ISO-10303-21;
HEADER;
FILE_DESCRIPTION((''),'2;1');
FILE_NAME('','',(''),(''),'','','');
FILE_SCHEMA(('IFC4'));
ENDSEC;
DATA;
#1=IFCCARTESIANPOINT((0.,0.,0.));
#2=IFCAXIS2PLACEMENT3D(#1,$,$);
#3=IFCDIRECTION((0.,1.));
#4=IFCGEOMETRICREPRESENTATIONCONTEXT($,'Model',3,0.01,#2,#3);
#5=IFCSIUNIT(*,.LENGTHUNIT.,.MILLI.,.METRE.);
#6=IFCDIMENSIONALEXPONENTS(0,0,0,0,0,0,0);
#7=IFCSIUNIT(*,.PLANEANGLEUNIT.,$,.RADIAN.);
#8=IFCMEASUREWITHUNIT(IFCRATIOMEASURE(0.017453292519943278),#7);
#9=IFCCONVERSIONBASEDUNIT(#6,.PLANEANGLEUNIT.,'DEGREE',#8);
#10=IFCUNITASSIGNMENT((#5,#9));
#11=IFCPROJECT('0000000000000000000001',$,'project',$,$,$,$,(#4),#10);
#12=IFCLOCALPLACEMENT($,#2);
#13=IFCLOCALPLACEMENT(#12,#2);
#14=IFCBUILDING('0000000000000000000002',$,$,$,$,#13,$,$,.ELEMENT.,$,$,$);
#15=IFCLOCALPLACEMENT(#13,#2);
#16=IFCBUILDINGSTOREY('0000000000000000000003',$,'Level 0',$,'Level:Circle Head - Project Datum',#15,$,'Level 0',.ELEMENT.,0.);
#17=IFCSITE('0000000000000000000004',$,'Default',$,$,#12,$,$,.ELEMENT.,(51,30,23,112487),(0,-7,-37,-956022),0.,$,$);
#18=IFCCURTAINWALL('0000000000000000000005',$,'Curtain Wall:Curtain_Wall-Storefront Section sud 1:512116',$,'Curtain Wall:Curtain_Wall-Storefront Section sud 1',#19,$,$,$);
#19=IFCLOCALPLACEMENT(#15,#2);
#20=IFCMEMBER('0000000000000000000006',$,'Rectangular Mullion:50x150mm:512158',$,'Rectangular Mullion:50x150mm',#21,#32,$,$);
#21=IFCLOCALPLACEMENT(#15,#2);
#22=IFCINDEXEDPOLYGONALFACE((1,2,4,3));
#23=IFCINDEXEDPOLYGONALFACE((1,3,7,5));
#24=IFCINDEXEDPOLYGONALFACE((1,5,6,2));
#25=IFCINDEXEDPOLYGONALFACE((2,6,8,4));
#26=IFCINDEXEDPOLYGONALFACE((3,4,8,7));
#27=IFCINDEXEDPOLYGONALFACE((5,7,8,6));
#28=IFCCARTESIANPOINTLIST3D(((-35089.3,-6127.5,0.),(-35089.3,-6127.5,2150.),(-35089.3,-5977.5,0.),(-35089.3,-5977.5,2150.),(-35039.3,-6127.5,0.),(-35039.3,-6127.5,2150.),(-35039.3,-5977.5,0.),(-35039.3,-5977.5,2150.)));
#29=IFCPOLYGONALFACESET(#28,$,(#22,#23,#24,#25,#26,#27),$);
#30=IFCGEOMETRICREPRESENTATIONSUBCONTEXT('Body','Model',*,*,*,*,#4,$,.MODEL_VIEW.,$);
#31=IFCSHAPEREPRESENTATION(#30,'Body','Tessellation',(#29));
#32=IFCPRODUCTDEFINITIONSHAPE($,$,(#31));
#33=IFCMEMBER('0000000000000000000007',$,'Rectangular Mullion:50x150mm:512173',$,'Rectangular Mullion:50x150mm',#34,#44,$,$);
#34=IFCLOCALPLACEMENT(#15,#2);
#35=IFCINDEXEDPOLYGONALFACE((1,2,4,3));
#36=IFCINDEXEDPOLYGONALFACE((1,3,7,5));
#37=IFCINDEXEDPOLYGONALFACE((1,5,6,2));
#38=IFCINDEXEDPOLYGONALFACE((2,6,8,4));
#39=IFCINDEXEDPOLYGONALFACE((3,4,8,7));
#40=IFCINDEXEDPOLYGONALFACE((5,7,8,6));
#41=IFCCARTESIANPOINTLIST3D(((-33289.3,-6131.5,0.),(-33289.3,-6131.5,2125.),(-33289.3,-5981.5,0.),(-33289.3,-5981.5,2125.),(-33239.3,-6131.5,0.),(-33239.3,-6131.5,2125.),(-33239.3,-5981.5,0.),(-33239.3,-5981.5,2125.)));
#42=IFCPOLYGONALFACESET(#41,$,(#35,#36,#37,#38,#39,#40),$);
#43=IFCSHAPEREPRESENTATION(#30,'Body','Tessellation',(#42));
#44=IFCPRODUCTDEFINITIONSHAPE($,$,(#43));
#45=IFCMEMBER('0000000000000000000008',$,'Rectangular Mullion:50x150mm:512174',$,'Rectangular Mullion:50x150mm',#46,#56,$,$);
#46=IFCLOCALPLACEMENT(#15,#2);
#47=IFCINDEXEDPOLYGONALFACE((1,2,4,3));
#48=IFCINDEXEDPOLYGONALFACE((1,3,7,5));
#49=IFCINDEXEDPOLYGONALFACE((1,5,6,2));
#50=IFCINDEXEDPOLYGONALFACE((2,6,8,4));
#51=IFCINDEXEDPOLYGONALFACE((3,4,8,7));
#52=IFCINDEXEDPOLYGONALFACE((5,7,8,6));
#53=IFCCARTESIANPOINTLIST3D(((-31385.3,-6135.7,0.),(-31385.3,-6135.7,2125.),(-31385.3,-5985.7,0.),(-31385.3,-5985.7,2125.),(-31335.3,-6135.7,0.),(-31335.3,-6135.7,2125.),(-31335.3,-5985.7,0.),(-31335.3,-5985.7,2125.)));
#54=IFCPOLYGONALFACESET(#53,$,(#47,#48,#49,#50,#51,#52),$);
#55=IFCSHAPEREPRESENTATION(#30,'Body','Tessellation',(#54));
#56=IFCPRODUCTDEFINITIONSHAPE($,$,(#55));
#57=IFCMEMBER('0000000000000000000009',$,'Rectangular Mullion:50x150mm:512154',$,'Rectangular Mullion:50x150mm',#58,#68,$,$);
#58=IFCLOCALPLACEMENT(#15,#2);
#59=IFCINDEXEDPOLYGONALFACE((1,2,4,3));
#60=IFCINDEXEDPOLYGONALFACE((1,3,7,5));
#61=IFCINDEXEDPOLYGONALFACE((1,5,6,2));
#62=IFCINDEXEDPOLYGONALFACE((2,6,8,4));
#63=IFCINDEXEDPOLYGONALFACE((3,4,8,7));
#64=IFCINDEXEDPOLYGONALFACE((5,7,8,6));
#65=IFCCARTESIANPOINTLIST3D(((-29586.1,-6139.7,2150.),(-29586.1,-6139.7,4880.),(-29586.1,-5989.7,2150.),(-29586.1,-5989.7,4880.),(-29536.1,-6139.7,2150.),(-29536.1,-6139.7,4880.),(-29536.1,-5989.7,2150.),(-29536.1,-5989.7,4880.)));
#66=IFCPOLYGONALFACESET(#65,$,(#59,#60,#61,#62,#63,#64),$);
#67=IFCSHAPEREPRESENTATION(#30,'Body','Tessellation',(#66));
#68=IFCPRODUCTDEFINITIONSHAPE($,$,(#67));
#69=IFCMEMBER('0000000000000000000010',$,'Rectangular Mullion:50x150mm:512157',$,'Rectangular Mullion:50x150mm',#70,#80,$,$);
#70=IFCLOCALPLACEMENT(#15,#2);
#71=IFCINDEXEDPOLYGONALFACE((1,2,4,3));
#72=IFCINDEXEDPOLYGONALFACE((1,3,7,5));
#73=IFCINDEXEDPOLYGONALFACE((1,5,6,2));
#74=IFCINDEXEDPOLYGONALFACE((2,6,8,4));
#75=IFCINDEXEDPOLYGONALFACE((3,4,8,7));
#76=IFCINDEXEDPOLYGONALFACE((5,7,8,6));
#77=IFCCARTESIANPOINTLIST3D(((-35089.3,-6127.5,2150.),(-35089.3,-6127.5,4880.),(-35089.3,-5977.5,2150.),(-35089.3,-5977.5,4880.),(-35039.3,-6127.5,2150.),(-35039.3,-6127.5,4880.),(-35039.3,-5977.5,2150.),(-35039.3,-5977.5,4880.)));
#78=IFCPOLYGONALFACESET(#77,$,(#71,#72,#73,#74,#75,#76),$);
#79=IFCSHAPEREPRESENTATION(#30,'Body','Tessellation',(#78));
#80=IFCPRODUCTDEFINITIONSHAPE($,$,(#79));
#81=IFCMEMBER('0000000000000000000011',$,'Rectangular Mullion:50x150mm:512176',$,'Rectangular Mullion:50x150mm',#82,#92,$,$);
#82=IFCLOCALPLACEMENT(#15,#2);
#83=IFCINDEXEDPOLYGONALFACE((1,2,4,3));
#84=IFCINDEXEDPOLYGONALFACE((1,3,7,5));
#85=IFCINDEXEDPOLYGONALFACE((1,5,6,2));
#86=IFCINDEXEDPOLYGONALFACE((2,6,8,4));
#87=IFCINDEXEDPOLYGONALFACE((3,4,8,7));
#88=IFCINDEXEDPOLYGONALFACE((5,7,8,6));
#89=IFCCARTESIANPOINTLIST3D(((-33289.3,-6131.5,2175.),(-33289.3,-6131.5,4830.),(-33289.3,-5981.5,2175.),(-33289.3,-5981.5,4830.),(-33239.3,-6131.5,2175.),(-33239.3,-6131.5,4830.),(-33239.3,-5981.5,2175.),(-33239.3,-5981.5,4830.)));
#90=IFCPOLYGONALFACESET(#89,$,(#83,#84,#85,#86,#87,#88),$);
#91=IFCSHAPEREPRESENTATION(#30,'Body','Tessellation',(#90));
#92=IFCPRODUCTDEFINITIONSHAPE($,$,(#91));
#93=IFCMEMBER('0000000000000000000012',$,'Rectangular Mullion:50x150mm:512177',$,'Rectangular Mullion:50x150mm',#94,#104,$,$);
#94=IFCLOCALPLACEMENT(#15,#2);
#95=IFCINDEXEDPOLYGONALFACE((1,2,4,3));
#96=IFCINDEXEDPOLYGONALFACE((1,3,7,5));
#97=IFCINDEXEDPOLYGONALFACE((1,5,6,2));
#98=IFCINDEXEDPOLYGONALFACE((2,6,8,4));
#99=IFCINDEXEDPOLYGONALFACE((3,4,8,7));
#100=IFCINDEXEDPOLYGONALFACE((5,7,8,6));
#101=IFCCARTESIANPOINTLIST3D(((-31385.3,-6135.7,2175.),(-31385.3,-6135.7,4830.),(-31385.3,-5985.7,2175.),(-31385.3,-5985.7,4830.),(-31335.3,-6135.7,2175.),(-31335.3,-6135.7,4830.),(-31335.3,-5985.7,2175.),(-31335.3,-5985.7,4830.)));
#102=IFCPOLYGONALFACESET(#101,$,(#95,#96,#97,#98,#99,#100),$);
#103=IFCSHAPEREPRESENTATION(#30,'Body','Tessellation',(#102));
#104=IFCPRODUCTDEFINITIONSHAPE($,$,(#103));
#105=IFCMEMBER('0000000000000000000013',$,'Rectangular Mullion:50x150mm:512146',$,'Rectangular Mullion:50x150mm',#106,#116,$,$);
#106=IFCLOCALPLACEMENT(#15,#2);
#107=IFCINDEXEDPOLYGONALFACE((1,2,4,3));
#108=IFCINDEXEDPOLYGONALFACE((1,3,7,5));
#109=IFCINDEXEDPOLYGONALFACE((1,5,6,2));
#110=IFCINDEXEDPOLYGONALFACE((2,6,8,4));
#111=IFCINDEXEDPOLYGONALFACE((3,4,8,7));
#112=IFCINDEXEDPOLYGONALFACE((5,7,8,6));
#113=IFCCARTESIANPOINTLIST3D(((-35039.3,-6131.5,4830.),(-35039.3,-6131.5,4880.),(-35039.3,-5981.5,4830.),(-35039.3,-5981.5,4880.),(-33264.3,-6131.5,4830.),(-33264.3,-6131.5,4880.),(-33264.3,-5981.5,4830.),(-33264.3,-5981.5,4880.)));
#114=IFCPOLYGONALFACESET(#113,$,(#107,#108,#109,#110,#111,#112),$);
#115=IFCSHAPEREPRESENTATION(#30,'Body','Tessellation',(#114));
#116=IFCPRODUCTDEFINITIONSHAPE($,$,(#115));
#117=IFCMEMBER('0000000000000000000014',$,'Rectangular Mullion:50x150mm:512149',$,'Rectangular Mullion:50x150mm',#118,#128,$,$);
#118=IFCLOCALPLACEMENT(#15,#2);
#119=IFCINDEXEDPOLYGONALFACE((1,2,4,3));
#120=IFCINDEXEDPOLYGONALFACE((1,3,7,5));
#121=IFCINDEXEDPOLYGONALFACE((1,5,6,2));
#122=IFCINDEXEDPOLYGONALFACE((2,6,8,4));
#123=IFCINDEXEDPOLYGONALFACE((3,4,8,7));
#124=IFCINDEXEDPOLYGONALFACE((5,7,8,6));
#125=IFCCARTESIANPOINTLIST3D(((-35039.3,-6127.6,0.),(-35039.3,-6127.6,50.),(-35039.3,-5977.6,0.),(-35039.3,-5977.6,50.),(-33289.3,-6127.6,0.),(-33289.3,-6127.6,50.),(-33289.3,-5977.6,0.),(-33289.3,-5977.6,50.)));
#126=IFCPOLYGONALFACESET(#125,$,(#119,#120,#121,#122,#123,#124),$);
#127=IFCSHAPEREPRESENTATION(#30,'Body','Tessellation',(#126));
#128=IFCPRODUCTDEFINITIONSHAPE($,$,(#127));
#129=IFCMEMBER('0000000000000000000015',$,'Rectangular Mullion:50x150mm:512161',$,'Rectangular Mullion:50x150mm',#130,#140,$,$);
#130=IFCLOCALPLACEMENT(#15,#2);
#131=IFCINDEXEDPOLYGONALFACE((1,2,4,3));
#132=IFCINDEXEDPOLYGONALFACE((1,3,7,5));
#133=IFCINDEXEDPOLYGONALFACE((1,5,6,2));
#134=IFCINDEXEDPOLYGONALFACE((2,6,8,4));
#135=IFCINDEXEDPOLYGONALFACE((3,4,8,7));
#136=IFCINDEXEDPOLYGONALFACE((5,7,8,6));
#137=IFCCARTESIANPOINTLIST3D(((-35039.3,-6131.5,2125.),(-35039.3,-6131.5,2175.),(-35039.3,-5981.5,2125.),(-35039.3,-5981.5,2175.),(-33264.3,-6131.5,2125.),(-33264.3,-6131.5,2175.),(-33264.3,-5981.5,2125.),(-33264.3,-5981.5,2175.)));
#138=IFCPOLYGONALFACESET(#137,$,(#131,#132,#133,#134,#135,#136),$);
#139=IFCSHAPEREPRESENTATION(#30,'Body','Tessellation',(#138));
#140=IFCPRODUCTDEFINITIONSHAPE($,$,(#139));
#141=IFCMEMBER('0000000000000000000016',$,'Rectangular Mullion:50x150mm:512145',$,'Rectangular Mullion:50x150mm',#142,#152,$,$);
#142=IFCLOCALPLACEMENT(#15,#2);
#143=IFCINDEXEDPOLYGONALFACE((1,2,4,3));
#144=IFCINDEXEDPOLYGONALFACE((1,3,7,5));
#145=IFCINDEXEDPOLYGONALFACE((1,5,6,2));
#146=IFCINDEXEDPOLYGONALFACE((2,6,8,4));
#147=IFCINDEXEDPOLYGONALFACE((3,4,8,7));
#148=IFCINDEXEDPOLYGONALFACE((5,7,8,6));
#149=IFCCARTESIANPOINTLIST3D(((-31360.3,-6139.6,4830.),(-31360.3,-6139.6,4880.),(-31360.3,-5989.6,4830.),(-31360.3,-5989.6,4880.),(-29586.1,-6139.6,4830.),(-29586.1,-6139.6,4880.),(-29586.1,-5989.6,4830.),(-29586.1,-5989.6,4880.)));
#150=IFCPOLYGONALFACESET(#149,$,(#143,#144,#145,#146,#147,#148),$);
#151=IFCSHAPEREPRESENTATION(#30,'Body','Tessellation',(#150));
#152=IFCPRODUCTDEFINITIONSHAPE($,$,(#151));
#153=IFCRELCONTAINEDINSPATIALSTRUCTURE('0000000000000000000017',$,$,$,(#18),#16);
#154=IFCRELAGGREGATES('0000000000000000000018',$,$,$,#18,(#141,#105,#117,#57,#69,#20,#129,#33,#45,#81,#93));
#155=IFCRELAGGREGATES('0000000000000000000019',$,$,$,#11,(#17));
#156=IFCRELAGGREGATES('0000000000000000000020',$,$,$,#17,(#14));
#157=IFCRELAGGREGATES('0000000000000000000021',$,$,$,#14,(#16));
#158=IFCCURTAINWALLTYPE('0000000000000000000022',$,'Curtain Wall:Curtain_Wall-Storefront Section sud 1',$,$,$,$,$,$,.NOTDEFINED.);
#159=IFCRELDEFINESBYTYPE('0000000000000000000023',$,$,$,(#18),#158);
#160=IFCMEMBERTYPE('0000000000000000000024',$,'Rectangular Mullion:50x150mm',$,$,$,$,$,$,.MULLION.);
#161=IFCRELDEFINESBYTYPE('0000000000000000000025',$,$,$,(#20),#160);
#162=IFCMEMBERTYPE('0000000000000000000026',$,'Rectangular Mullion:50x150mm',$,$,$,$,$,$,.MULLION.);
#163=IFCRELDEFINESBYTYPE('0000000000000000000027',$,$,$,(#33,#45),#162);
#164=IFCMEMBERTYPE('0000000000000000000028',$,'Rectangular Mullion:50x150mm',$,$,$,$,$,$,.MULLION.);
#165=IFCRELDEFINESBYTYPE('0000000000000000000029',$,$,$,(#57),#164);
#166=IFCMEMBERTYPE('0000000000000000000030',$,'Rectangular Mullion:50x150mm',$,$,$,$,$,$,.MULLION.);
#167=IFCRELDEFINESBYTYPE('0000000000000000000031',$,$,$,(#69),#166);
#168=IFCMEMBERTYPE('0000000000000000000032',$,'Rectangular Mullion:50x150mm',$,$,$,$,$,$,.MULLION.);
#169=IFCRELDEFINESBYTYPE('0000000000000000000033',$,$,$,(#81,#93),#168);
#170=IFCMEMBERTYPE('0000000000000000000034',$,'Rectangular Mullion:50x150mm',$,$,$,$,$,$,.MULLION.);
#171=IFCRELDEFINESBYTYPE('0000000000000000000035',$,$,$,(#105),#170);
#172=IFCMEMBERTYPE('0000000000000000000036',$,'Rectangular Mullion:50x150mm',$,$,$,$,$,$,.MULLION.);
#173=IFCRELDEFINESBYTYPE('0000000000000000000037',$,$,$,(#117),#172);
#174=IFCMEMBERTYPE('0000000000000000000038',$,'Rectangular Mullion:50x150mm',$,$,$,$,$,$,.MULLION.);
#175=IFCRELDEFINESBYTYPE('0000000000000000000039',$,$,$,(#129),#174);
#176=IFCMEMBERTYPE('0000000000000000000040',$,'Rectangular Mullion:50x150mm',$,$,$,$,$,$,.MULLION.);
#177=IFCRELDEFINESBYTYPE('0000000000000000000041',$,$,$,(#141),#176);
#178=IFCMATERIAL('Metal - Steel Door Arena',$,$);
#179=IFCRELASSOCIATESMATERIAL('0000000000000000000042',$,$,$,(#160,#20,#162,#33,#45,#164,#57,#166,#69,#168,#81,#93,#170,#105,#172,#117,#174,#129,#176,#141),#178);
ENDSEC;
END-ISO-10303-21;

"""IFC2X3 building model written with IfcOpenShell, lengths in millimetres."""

from ifc_helpers import new_model, entity, si_unit, converted_unit, direction, frame, origin, origin_2d_with_axis, place, context, subcontext, project, spatial, rectangle, extrude, source, transform, mapped, material, type_object, type_shapes, element, aggregate, save


model = new_model("IFC2X3")

# Units and contexts
model_context = context("Model", 3, precision=0.01, world=origin(), true_north=direction((0.0, 1.0)))
body_context = subcontext(model_context, "Body", "Model", "MODEL_VIEW")
ifc_project = project(units=[si_unit("LENGTHUNIT", "METRE", prefix="MILLI"), converted_unit("PLANEANGLEUNIT", "DEGREE", entity("IfcRatioMeasure", 0.017453292519943278), si_unit("PLANEANGLEUNIT", "RADIAN"), dimensions=[0, 0, 0, 0, 0, 0, 0])], contexts=[model_context])

# Site, building, storey
site_placement = place(None, origin())
site = spatial("IfcSite", under=ifc_project, at=site_placement, Name="Default", CompositionType="ELEMENT", RefLatitude=(51, 30, 23, 112487), RefLongitude=(0, -7, -37, -956022), RefElevation=0.0)
building_placement = place(site_placement, origin())
building = spatial("IfcBuilding", under=site, at=building_placement, CompositionType="ELEMENT")
storey_placement = place(building_placement, origin())
storey = spatial("IfcBuildingStorey", under=building, at=storey_placement, Name="Level 0", ObjectType="Level:Circle Head - Project Datum", LongName="Level 0", CompositionType="ELEMENT", Elevation=0.0)

# Curtain wall, members
curtain_wall_type = type_object("IfcCurtainWallType", Name="Curtain Wall:Curtain_Wall-Storefront Section sud 1", PredefinedType="NOTDEFINED")
curtain_wall_placement = place(storey_placement, origin())
curtain_wall = element("IfcCurtainWall", 1, at=curtain_wall_placement, inside=storey, type_object=curtain_wall_type, Name="Curtain Wall:Curtain_Wall-Storefront Section sud 1:512116", ObjectType="Curtain Wall:Curtain_Wall-Storefront Section sud 1")
ifc_material_1 = material(Name="Metal - Steel Door Arena")
member_type_1 = type_object("IfcMemberType", Name="Rectangular Mullion:50x150mm", PredefinedType="MULLION", material=ifc_material_1)
shared_shape_1 = source(origin(), body_context, "Body", "SweptSolid", [
    extrude(rectangle(XDim=150.0, YDim=50.0, at=origin_2d_with_axis()), frame((-25.0, 0.0, -2150.0), z_axis=(0.0, 0.0, 1.0), x_axis=(0.0, -1.0, 0.0)), (0.0, 0.0, 1.0), 2150.0),
])
type_shapes(member_type_1, [shared_shape_1])
member_1_placement = place(curtain_wall_placement, frame((-35089.3, -6052.5, 2150.0), z_axis=(0.0, 0.0, 1.0), x_axis=(-1.0, 0.0, 0.0)))
member_1 = element("IfcMember", 2, at=member_1_placement, type_object=member_type_1, material=ifc_material_1, Name="Rectangular Mullion:50x150mm:512158", ObjectType="Rectangular Mullion:50x150mm", context=body_context, shape_type="MappedRepresentation", body=[
    mapped(shared_shape_1, transform((0.0, 0.0, 0.0), scale=1.0)),
])
member_type_2 = type_object("IfcMemberType", Name="Rectangular Mullion:50x150mm", PredefinedType="MULLION", material=ifc_material_1)
shared_shape_2 = source(origin(), body_context, "Body", "SweptSolid", [
    extrude(rectangle(XDim=150.0, YDim=50.0, at=origin_2d_with_axis()), frame((0.0, 0.0, -2125.0), z_axis=(0.0, 0.0, 1.0), x_axis=(0.0, -1.0, 0.0)), (0.0, 0.0, 1.0), 2125.0),
])
type_shapes(member_type_2, [shared_shape_2])
member_2_placement = place(curtain_wall_placement, frame((-33264.3, -6056.5, 0.0), z_axis=(0.0, 0.0, -1.0), x_axis=(1.0, 0.0, 0.0)))
member_2 = element("IfcMember", 3, at=member_2_placement, type_object=member_type_2, material=ifc_material_1, Name="Rectangular Mullion:50x150mm:512173", ObjectType="Rectangular Mullion:50x150mm", context=body_context, shape_type="MappedRepresentation", body=[
    mapped(shared_shape_2, transform((0.0, 0.0, 0.0), scale=1.0)),
])
member_3_placement = place(curtain_wall_placement, frame((-31360.3, -6060.7, 0.0), z_axis=(0.0, 0.0, -1.0), x_axis=(1.0, 0.0, 0.0)))
member_3 = element("IfcMember", 4, at=member_3_placement, type_object=member_type_2, material=ifc_material_1, Name="Rectangular Mullion:50x150mm:512174", ObjectType="Rectangular Mullion:50x150mm", context=body_context, shape_type="MappedRepresentation", body=[
    mapped(shared_shape_2, transform((0.0, 0.0, 0.0), scale=1.0)),
])
member_type_3 = type_object("IfcMemberType", Name="Rectangular Mullion:50x150mm", PredefinedType="MULLION", material=ifc_material_1)
shared_shape_3 = source(origin(), body_context, "Body", "SweptSolid", [
    extrude(rectangle(XDim=150.0, YDim=50.0, at=origin_2d_with_axis()), frame((-25.0, 0.0, -2730.0), z_axis=(0.0, 0.0, 1.0), x_axis=(0.0, -1.0, 0.0)), (0.0, 0.0, 1.0), 2730.0),
])
type_shapes(member_type_3, [shared_shape_3])
member_4_placement = place(curtain_wall_placement, frame((-29536.1, -6064.7, 2150.0), z_axis=(0.0, 0.0, -1.0), x_axis=(1.0, 0.0, 0.0)))
member_4 = element("IfcMember", 5, at=member_4_placement, type_object=member_type_3, material=ifc_material_1, Name="Rectangular Mullion:50x150mm:512154", ObjectType="Rectangular Mullion:50x150mm", context=body_context, shape_type="MappedRepresentation", body=[
    mapped(shared_shape_3, transform((0.0, 0.0, 0.0), scale=1.0)),
])
member_type_4 = type_object("IfcMemberType", Name="Rectangular Mullion:50x150mm", PredefinedType="MULLION", material=ifc_material_1)
shared_shape_4 = source(origin(), body_context, "Body", "SweptSolid", [
    extrude(rectangle(XDim=150.0, YDim=50.0, at=origin_2d_with_axis()), frame((-25.0, 0.0, -2730.0), z_axis=(0.0, 0.0, 1.0), x_axis=(0.0, -1.0, 0.0)), (0.0, 0.0, 1.0), 2730.0),
])
type_shapes(member_type_4, [shared_shape_4])
member_5_placement = place(curtain_wall_placement, frame((-35089.3, -6052.5, 4880.0), z_axis=(0.0, 0.0, 1.0), x_axis=(-1.0, 0.0, 0.0)))
member_5 = element("IfcMember", 6, at=member_5_placement, type_object=member_type_4, material=ifc_material_1, Name="Rectangular Mullion:50x150mm:512157", ObjectType="Rectangular Mullion:50x150mm", context=body_context, shape_type="MappedRepresentation", body=[
    mapped(shared_shape_4, transform((0.0, 0.0, 0.0), scale=1.0)),
])
member_type_5 = type_object("IfcMemberType", Name="Rectangular Mullion:50x150mm", PredefinedType="MULLION", material=ifc_material_1)
shared_shape_5 = source(origin(), body_context, "Body", "SweptSolid", [
    extrude(rectangle(XDim=150.0, YDim=50.0, at=origin_2d_with_axis()), frame((0.0, 0.0, -2655.0), z_axis=(0.0, 0.0, 1.0), x_axis=(0.0, -1.0, 0.0)), (0.0, 0.0, 1.0), 2655.0),
])
type_shapes(member_type_5, [shared_shape_5])
member_6_placement = place(curtain_wall_placement, frame((-33264.3, -6056.5, 2175.0), z_axis=(0.0, 0.0, -1.0), x_axis=(1.0, 0.0, 0.0)))
member_6 = element("IfcMember", 7, at=member_6_placement, type_object=member_type_5, material=ifc_material_1, Name="Rectangular Mullion:50x150mm:512176", ObjectType="Rectangular Mullion:50x150mm", context=body_context, shape_type="MappedRepresentation", body=[
    mapped(shared_shape_5, transform((0.0, 0.0, 0.0), scale=1.0)),
])
member_7_placement = place(curtain_wall_placement, frame((-31360.3, -6060.7, 2175.0), z_axis=(0.0, 0.0, -1.0), x_axis=(1.0, 0.0, 0.0)))
member_7 = element("IfcMember", 8, at=member_7_placement, type_object=member_type_5, material=ifc_material_1, Name="Rectangular Mullion:50x150mm:512177", ObjectType="Rectangular Mullion:50x150mm", context=body_context, shape_type="MappedRepresentation", body=[
    mapped(shared_shape_5, transform((0.0, 0.0, 0.0), scale=1.0)),
])
member_type_6 = type_object("IfcMemberType", Name="Rectangular Mullion:50x150mm", PredefinedType="MULLION", material=ifc_material_1)
shared_shape_6 = source(origin(), body_context, "Body", "SweptSolid", [
    extrude(rectangle(XDim=150.0, YDim=50.0, at=origin_2d_with_axis()), frame((-25.0, 0.0, -1775.0), z_axis=(0.0, 0.0, 1.0), x_axis=(0.0, -1.0, 0.0)), (0.0, 0.0, 1.0), 1775.0),
])
type_shapes(member_type_6, [shared_shape_6])
member_8_placement = place(curtain_wall_placement, frame((-33264.3, -6056.5, 4880.0), z_axis=(1.0, 0.0, 0.0), x_axis=(0.0, 0.0, 1.0)))
member_8 = element("IfcMember", 9, at=member_8_placement, type_object=member_type_6, material=ifc_material_1, Name="Rectangular Mullion:50x150mm:512146", ObjectType="Rectangular Mullion:50x150mm", context=body_context, shape_type="MappedRepresentation", body=[
    mapped(shared_shape_6, transform((0.0, 0.0, 0.0), scale=1.0)),
])
member_type_7 = type_object("IfcMemberType", Name="Rectangular Mullion:50x150mm", PredefinedType="MULLION", material=ifc_material_1)
shared_shape_7 = source(origin(), body_context, "Body", "SweptSolid", [
    extrude(rectangle(XDim=150.0, YDim=50.0, at=origin_2d_with_axis()), frame((-25.0, 0.0, -1750.0), z_axis=(0.0, 0.0, 1.0), x_axis=(0.0, -1.0, 0.0)), (0.0, 0.0, 1.0), 1750.0),
])
type_shapes(member_type_7, [shared_shape_7])
member_9_placement = place(curtain_wall_placement, frame((-35039.3, -6052.6, 0.0), z_axis=(-1.0, 0.0, 0.0), x_axis=(0.0, 0.0, -1.0)))
member_9 = element("IfcMember", 10, at=member_9_placement, type_object=member_type_7, material=ifc_material_1, Name="Rectangular Mullion:50x150mm:512149", ObjectType="Rectangular Mullion:50x150mm", context=body_context, shape_type="MappedRepresentation", body=[
    mapped(shared_shape_7, transform((0.0, 0.0, 0.0), scale=1.0)),
])
member_type_8 = type_object("IfcMemberType", Name="Rectangular Mullion:50x150mm", PredefinedType="MULLION", material=ifc_material_1)
shared_shape_8 = source(origin(), body_context, "Body", "SweptSolid", [
    extrude(rectangle(XDim=150.0, YDim=50.0, at=origin_2d_with_axis()), frame((0.0, 0.0, -1775.0), z_axis=(0.0, 0.0, 1.0), x_axis=(0.0, -1.0, 0.0)), (0.0, 0.0, 1.0), 1775.0),
])
type_shapes(member_type_8, [shared_shape_8])
member_10_placement = place(curtain_wall_placement, frame((-33264.3, -6056.5, 2150.0), z_axis=(1.0, 0.0, 0.0), x_axis=(0.0, 0.0, 1.0)))
member_10 = element("IfcMember", 11, at=member_10_placement, type_object=member_type_8, material=ifc_material_1, Name="Rectangular Mullion:50x150mm:512161", ObjectType="Rectangular Mullion:50x150mm", context=body_context, shape_type="MappedRepresentation", body=[
    mapped(shared_shape_8, transform((0.0, 0.0, 0.0), scale=1.0)),
])
member_type_9 = type_object("IfcMemberType", Name="Rectangular Mullion:50x150mm", PredefinedType="MULLION", material=ifc_material_1)
shared_shape_9 = source(origin(), body_context, "Body", "SweptSolid", [
    extrude(rectangle(XDim=150.0, YDim=50.0, at=origin_2d_with_axis()), frame((-25.0, 0.0, -1774.2), z_axis=(0.0, 0.0, 1.0), x_axis=(0.0, -1.0, 0.0)), (0.0, 0.0, 1.0), 1774.2),
])
type_shapes(member_type_9, [shared_shape_9])
member_11_placement = place(curtain_wall_placement, frame((-29586.1, -6064.6, 4880.0), z_axis=(1.0, 0.0, 0.0), x_axis=(0.0, 0.0, 1.0)))
member_11 = element("IfcMember", 12, at=member_11_placement, type_object=member_type_9, material=ifc_material_1, Name="Rectangular Mullion:50x150mm:512145", ObjectType="Rectangular Mullion:50x150mm", context=body_context, shape_type="MappedRepresentation", body=[
    mapped(shared_shape_9, transform((0.0, 0.0, 0.0), scale=1.0)),
])
aggregate(curtain_wall, [member_11, member_8, member_9, member_4, member_5, member_1, member_10, member_2, member_3, member_6, member_7])

save(model, "model.ifc")
